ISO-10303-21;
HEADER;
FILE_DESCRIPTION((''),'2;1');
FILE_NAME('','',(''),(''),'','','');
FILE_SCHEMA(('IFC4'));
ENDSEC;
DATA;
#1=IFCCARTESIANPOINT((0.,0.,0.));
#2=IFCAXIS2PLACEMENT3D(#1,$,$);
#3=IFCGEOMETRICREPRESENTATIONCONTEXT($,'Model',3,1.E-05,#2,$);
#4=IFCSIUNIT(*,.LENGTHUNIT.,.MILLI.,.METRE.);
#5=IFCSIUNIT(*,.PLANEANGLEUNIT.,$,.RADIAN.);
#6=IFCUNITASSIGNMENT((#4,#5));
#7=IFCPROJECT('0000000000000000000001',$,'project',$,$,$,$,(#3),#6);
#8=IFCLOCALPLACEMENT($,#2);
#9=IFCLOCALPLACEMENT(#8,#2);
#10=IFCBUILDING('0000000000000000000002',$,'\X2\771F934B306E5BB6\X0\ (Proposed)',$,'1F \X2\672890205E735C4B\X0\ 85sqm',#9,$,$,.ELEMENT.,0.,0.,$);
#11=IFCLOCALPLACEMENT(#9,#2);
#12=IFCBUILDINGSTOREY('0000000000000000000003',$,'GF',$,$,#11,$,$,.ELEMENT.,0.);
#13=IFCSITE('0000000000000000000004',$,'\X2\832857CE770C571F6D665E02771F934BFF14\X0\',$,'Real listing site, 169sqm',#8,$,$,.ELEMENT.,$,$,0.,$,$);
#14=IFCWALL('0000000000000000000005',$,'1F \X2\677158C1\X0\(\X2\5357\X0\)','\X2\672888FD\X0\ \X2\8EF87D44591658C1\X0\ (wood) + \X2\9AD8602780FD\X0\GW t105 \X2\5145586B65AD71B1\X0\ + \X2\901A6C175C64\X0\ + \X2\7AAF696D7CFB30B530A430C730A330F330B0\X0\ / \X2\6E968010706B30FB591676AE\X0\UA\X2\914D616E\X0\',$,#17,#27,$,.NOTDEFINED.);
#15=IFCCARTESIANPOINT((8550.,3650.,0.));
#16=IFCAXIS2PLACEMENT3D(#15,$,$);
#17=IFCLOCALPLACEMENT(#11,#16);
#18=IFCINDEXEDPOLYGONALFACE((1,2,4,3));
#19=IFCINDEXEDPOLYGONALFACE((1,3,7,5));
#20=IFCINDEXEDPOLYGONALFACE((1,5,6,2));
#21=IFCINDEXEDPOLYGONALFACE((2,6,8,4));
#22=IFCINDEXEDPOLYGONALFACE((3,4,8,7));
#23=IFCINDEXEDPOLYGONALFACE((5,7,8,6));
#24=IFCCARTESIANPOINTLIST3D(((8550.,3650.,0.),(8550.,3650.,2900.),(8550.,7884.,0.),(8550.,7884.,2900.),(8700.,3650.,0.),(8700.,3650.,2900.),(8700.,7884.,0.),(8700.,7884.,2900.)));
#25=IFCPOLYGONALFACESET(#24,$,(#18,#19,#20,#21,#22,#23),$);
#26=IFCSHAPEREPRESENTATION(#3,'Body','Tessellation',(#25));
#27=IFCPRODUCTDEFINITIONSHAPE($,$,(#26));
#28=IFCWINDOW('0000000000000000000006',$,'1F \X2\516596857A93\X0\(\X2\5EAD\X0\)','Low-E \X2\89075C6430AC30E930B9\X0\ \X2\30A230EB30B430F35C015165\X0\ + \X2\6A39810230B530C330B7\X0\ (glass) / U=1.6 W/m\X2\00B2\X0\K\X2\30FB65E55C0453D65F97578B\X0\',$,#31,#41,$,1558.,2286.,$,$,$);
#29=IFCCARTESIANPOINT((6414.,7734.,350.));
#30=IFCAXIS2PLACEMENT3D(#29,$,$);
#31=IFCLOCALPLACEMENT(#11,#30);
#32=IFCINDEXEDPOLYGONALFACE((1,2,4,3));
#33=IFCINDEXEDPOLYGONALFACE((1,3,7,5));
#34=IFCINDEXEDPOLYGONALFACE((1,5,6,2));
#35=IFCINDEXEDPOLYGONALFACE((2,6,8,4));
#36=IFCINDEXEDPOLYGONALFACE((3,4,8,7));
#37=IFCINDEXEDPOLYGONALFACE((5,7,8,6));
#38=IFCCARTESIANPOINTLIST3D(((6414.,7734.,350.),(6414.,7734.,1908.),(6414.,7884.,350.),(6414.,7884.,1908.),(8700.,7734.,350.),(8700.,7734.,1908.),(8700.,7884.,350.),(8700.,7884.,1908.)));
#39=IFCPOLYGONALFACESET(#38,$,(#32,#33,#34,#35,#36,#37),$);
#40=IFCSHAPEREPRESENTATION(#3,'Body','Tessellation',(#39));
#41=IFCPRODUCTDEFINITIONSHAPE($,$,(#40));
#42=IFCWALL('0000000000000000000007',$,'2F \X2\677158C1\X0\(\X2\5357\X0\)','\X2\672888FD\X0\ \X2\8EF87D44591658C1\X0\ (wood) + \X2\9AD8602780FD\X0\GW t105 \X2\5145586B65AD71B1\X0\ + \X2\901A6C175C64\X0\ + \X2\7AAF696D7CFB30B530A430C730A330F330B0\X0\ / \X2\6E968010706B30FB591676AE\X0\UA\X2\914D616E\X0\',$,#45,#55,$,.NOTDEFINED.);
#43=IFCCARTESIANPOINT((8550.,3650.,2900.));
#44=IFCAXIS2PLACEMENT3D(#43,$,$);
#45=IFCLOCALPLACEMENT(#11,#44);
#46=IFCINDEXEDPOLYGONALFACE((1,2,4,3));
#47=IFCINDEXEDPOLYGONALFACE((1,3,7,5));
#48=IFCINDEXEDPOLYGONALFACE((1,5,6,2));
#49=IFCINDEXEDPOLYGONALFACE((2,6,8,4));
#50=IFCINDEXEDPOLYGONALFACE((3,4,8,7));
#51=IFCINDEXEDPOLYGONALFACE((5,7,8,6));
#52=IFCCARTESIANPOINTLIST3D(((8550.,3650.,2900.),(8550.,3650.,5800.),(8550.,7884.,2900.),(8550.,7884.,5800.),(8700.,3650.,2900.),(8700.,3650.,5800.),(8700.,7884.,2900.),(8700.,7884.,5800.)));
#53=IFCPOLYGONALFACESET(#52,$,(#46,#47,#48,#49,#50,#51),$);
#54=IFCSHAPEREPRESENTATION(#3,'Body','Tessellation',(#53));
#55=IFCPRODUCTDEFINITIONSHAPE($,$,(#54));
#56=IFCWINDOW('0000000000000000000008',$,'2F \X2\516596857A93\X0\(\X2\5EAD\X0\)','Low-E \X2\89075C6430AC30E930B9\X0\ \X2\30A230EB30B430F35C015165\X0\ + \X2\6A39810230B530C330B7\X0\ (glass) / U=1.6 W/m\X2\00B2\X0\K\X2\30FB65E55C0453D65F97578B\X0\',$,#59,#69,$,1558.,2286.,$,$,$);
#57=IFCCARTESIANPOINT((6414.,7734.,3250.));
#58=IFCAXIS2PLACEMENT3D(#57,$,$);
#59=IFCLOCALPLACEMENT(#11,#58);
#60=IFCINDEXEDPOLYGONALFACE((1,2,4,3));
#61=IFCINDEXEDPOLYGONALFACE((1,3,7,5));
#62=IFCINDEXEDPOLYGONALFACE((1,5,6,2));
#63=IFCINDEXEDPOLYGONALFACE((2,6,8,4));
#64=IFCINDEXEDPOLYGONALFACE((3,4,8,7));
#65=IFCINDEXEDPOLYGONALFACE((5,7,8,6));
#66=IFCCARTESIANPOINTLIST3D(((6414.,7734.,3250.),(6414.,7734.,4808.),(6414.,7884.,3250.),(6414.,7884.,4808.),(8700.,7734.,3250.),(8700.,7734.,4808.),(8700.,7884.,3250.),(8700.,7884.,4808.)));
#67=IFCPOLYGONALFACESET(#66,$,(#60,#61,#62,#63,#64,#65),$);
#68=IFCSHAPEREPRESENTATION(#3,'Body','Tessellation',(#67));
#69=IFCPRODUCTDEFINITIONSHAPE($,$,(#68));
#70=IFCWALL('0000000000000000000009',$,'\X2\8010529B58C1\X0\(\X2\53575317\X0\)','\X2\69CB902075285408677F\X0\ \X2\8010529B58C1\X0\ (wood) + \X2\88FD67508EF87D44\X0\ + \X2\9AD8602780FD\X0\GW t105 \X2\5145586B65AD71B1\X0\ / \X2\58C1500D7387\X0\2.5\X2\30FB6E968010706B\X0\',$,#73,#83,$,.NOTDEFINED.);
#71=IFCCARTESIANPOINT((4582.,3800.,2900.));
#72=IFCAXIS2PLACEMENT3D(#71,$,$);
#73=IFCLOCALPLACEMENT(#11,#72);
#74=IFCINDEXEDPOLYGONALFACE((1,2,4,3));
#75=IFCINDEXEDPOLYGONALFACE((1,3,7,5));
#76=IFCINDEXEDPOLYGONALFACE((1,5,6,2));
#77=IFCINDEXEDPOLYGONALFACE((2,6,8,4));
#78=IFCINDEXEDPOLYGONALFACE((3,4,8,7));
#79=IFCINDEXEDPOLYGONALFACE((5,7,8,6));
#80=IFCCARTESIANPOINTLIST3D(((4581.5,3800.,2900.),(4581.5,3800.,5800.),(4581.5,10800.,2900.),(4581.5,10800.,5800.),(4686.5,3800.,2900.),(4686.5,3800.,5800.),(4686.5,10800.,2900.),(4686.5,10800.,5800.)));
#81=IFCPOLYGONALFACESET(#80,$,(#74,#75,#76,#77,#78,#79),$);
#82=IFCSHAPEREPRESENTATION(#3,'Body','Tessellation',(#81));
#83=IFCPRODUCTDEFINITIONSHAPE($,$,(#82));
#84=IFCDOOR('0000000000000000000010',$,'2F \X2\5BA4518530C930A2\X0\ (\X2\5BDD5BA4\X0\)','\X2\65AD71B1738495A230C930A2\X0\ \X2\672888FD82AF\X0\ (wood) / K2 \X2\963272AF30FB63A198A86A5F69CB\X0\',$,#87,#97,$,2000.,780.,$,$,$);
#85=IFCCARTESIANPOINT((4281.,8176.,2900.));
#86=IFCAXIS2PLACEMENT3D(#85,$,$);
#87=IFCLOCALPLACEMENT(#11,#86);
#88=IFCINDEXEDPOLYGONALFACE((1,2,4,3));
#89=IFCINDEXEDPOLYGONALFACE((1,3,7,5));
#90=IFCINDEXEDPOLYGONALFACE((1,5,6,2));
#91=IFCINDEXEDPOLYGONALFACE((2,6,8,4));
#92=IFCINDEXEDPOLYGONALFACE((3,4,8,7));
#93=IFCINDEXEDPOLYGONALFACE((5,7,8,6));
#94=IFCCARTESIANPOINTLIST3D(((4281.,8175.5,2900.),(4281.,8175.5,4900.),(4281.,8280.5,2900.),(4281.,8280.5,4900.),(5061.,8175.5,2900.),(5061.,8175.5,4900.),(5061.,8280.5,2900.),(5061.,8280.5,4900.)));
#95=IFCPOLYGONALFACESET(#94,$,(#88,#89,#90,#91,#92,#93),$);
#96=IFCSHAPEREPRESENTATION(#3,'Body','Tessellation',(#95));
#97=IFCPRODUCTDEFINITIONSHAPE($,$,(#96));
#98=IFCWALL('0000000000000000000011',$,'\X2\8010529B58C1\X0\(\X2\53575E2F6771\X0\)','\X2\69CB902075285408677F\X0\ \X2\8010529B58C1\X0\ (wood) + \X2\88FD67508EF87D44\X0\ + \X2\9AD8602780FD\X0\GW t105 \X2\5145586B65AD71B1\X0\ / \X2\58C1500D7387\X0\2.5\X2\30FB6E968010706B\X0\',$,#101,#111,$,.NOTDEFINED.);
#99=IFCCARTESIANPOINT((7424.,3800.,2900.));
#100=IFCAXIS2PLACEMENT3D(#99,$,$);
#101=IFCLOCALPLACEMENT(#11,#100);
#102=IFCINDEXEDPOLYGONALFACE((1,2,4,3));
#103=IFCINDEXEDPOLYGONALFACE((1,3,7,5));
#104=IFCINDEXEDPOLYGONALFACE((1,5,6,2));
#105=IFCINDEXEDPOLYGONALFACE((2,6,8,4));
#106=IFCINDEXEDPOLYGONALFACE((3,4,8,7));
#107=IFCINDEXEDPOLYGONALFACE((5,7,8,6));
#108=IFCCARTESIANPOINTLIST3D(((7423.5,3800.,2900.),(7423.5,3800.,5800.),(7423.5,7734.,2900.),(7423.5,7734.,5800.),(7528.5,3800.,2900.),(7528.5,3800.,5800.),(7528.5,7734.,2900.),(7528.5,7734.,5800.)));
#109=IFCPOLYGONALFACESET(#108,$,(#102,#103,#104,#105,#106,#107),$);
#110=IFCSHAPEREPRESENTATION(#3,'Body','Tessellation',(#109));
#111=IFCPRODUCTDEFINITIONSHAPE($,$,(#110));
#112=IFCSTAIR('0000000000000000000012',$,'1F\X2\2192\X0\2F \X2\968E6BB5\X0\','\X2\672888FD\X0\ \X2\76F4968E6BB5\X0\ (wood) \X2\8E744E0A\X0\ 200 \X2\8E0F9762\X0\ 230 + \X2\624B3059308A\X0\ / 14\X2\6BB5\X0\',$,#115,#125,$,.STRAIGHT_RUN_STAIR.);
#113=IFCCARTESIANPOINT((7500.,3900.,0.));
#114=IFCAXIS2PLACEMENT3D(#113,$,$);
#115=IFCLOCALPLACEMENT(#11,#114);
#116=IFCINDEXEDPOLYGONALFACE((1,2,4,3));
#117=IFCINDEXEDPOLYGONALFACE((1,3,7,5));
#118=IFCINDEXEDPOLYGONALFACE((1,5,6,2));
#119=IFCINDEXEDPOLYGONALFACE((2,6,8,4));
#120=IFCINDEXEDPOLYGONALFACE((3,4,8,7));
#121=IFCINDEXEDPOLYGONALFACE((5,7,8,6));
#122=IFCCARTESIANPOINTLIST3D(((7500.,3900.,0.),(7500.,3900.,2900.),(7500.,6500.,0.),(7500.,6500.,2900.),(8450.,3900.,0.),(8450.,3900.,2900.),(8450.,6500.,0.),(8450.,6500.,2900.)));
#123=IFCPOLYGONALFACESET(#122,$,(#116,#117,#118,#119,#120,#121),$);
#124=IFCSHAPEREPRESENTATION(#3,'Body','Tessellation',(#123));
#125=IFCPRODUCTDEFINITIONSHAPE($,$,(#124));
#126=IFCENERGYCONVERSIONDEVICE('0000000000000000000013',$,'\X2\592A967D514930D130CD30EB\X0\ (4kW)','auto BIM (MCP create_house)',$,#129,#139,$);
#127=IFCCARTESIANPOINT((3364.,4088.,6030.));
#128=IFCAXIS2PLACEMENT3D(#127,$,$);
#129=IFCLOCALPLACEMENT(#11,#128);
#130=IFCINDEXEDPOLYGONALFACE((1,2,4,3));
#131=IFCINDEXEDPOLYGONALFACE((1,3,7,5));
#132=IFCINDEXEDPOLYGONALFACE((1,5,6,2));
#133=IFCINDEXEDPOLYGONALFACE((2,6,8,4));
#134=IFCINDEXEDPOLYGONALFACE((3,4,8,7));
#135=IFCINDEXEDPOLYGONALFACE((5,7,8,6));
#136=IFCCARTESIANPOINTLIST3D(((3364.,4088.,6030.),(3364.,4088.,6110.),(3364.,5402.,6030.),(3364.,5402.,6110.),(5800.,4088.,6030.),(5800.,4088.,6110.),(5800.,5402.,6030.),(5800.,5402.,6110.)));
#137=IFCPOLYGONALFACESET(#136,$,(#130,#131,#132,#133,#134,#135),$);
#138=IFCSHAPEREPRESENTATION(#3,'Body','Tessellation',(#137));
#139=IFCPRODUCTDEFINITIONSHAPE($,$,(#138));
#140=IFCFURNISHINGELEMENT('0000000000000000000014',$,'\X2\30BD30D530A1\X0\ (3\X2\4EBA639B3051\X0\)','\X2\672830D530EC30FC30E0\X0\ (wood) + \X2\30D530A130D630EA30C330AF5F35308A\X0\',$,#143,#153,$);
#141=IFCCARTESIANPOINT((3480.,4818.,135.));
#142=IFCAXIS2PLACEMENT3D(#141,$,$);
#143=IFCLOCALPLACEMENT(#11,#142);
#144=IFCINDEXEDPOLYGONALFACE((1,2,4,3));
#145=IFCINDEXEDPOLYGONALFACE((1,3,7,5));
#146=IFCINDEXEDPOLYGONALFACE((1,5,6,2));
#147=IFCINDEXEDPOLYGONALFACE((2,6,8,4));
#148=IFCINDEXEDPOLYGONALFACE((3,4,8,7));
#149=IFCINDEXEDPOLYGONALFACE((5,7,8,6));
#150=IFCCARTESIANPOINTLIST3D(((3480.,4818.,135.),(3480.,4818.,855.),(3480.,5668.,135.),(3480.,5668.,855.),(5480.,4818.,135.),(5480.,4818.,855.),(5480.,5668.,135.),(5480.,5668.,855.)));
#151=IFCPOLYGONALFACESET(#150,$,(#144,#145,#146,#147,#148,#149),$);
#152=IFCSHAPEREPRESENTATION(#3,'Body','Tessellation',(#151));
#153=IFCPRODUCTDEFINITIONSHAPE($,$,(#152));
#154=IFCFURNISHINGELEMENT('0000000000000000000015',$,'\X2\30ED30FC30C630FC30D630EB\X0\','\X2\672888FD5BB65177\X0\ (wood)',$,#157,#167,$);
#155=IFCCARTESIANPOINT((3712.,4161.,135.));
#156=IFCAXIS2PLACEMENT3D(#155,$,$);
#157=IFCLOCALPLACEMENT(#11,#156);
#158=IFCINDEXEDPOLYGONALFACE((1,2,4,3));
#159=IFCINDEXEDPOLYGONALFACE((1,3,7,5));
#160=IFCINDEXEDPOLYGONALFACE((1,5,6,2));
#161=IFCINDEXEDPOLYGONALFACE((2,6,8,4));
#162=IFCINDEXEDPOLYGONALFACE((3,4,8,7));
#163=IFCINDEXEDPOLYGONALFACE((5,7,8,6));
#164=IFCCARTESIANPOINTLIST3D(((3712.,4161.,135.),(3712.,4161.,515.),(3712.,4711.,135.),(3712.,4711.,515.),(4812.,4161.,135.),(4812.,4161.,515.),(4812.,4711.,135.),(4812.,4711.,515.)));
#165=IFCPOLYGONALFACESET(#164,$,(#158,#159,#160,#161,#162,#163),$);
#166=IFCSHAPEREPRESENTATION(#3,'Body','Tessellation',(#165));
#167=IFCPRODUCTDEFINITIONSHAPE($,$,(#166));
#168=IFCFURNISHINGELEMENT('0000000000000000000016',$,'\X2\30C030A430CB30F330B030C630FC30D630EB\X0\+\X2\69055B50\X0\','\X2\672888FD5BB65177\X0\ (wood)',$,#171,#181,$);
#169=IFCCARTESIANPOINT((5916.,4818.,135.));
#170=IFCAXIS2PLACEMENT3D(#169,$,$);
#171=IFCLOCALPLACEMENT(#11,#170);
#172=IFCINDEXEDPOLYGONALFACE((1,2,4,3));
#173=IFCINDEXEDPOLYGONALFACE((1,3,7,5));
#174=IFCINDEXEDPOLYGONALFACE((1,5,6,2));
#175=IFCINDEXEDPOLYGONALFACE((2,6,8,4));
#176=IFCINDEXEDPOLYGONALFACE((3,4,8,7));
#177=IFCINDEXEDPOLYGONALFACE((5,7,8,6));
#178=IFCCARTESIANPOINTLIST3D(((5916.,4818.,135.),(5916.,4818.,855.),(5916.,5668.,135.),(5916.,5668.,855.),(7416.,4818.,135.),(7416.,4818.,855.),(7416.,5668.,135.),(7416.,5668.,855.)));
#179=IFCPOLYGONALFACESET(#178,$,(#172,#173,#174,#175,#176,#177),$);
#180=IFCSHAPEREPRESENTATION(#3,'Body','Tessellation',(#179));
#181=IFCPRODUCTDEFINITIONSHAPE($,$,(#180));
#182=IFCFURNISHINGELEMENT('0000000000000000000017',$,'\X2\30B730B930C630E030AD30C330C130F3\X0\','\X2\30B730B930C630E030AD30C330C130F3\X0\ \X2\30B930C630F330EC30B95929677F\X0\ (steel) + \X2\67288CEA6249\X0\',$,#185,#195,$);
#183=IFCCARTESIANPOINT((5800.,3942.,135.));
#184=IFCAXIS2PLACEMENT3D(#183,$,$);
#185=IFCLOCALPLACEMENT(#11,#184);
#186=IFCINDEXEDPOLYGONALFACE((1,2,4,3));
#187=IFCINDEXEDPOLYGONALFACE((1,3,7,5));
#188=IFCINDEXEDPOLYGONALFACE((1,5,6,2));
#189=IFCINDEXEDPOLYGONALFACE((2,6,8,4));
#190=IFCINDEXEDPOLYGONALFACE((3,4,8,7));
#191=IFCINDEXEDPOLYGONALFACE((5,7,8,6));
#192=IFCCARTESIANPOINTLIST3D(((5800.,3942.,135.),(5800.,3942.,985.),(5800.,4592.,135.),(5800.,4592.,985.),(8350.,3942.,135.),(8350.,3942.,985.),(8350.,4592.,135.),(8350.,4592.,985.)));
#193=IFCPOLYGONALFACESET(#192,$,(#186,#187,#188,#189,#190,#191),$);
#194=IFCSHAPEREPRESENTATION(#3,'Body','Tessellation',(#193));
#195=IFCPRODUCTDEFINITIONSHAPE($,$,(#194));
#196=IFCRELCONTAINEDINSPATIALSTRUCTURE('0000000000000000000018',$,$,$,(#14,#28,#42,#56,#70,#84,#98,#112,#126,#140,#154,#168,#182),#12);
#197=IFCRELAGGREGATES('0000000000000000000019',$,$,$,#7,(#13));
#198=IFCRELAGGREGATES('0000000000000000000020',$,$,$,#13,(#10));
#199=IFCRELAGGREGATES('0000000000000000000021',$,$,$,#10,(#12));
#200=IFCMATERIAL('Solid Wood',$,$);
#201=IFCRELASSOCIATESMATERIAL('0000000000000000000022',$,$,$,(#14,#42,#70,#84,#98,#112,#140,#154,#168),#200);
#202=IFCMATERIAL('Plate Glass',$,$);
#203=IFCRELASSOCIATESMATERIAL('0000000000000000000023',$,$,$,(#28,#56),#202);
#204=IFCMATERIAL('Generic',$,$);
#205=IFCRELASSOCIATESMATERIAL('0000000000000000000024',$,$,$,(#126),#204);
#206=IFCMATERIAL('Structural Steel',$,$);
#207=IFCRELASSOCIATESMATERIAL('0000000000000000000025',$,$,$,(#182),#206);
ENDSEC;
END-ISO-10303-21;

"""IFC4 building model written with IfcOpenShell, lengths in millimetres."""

from ifc_helpers import new_model, si_unit, frame, frame_2d, origin, place, context, project, spatial, rectangle, extrude, material, element, fill, save


model = new_model("IFC4")

# Units and contexts
model_context = context("Model", 3, precision=1e-05, world=origin())
ifc_project = project(units=[si_unit("LENGTHUNIT", "METRE", prefix="MILLI"), si_unit("PLANEANGLEUNIT", "RADIAN")], contexts=[model_context])

# Site, building, storey
site_placement = place(None, origin())
site = spatial("IfcSite", under=ifc_project, at=site_placement, Name="茨城県土浦市真鍋４", ObjectType="Real listing site, 169sqm", CompositionType="ELEMENT", RefElevation=0.0)
building_placement = place(site_placement, origin())
building = spatial("IfcBuilding", under=site, at=building_placement, Name="真鍋の家 (Proposed)", ObjectType="1F 木造平屋 85sqm", CompositionType="ELEMENT", ElevationOfRefHeight=0.0, ElevationOfTerrain=0.0)
storey_placement = place(building_placement, origin())
storey = spatial("IfcBuildingStorey", under=building, at=storey_placement, Name="GF", CompositionType="ELEMENT", Elevation=0.0)

# Wall, opening, window
ifc_material_1 = material(Name="Solid Wood")
wall_1_placement = place(storey_placement, frame((8550.0, 3650.0, 0.0)))
wall_1 = element("IfcWall", 1, at=wall_1_placement, inside=storey, material=ifc_material_1, Name="1F 東壁(南)", Description="木製 軸組外壁 (wood) + 高性能GW t105 充填断熱 + 通気層 + 窯業系サイディング / 準耐火・外皮UA配慮", PredefinedType="NOTDEFINED", context=model_context, shape_type="SweptSolid", body=[
    extrude(rectangle(XDim=150.0, YDim=4234.0, at=frame_2d((75.0, 2117.0))), frame((8550.0, 3650.0, 0.0)), (0.0, 0.0, 1.0), 2900.0),
])
opening_1_placement = place(storey_placement, frame((6414.0, 7734.0, 350.0)))
opening_1 = element("IfcOpeningElement", 2, at=opening_1_placement, cuts=wall_1, PredefinedType="NOTDEFINED", context=model_context, shape_type="SweptSolid", body=[
    extrude(rectangle(XDim=2286.0, YDim=150.0, at=frame_2d((1143.0, 75.0))), frame((6414.0, 7734.0, 350.0)), (0.0, 0.0, 1.0), 1558.0),
])
ifc_material_2 = material(Name="Plate Glass")
window_1_placement = place(storey_placement, frame((6414.0, 7734.0, 350.0)))
window_1 = element("IfcWindow", 3, at=window_1_placement, inside=storey, material=ifc_material_2, Name="1F 入隅窓(庭)", Description="Low-E 複層ガラス アルゴン封入 + 樹脂サッシ (glass) / U=1.6 W/m²K・日射取得型", OverallHeight=1558.0, OverallWidth=2286.0, context=model_context, shape_type="SweptSolid", body=[
    extrude(rectangle(XDim=2286.0, YDim=150.0, at=frame_2d((1143.0, 75.0))), frame((6414.0, 7734.0, 350.0)), (0.0, 0.0, 1.0), 1558.0),
])
fill(opening_1, window_1)

# Wall, opening, window
wall_2_placement = place(storey_placement, frame((8550.0, 3650.0, 2900.0)))
wall_2 = element("IfcWall", 4, at=wall_2_placement, inside=storey, material=ifc_material_1, Name="2F 東壁(南)", Description="木製 軸組外壁 (wood) + 高性能GW t105 充填断熱 + 通気層 + 窯業系サイディング / 準耐火・外皮UA配慮", PredefinedType="NOTDEFINED", context=model_context, shape_type="SweptSolid", body=[
    extrude(rectangle(XDim=150.0, YDim=4234.0, at=frame_2d((75.0, 2117.0))), frame((8550.0, 3650.0, 2900.0)), (0.0, 0.0, 1.0), 2900.0),
])
opening_2_placement = place(storey_placement, frame((6414.0, 7734.0, 3250.0)))
opening_2 = element("IfcOpeningElement", 5, at=opening_2_placement, cuts=wall_2, PredefinedType="NOTDEFINED", context=model_context, shape_type="SweptSolid", body=[
    extrude(rectangle(XDim=2286.0, YDim=150.0, at=frame_2d((1143.0, 75.0))), frame((6414.0, 7734.0, 3250.0)), (0.0, 0.0, 1.0), 1558.0),
])
window_2_placement = place(storey_placement, frame((6414.0, 7734.0, 3250.0)))
window_2 = element("IfcWindow", 6, at=window_2_placement, inside=storey, material=ifc_material_2, Name="2F 入隅窓(庭)", Description="Low-E 複層ガラス アルゴン封入 + 樹脂サッシ (glass) / U=1.6 W/m²K・日射取得型", OverallHeight=1558.0, OverallWidth=2286.0, context=model_context, shape_type="SweptSolid", body=[
    extrude(rectangle(XDim=2286.0, YDim=150.0, at=frame_2d((1143.0, 75.0))), frame((6414.0, 7734.0, 3250.0)), (0.0, 0.0, 1.0), 1558.0),
])
fill(opening_2, window_2)

# Wall, opening, door
wall_3_placement = place(storey_placement, frame((4582.0, 3800.0, 2900.0)))
wall_3 = element("IfcWall", 7, at=wall_3_placement, inside=storey, material=ifc_material_1, Name="耐力壁(南北)", Description="構造用合板 耐力壁 (wood) + 製材軸組 + 高性能GW t105 充填断熱 / 壁倍率2.5・準耐火", PredefinedType="NOTDEFINED", context=model_context, shape_type="SweptSolid", body=[
    extrude(rectangle(XDim=105.0, YDim=7000.0, at=frame_2d((52.0, 3500.0))), frame((4582.0, 3800.0, 2900.0)), (0.0, 0.0, 1.0), 2900.0),
])
opening_3_placement = place(storey_placement, frame((4281.0, 8176.0, 2900.0)))
opening_3 = element("IfcOpeningElement", 8, at=opening_3_placement, cuts=wall_3, PredefinedType="NOTDEFINED", context=model_context, shape_type="SweptSolid", body=[
    extrude(rectangle(XDim=780.0, YDim=105.0, at=frame_2d((390.0, 52.0))), frame((4281.0, 8176.0, 2900.0)), (0.0, 0.0, 1.0), 2000.0),
])
door_1_placement = place(storey_placement, frame((4281.0, 8176.0, 2900.0)))
door_1 = element("IfcDoor", 9, at=door_1_placement, inside=storey, material=ifc_material_1, Name="2F 室内ドア (寝室)", Description="断熱玄関ドア 木製芯 (wood) / K2 防犯・採風機構", OverallHeight=2000.0, OverallWidth=780.0, context=model_context, shape_type="SweptSolid", body=[
    extrude(rectangle(XDim=780.0, YDim=105.0, at=frame_2d((390.0, 52.0))), frame((4281.0, 8176.0, 2900.0)), (0.0, 0.0, 1.0), 2000.0),
])
fill(opening_3, door_1)

# Wall
wall_4_placement = place(storey_placement, frame((7424.0, 3800.0, 2900.0)))
element("IfcWall", 10, at=wall_4_placement, inside=storey, material=ifc_material_1, Name="耐力壁(南帯東)", Description="構造用合板 耐力壁 (wood) + 製材軸組 + 高性能GW t105 充填断熱 / 壁倍率2.5・準耐火", PredefinedType="NOTDEFINED", context=model_context, shape_type="SweptSolid", body=[
    extrude(rectangle(XDim=105.0, YDim=3934.0, at=frame_2d((52.0, 1967.0))), frame((7424.0, 3800.0, 2900.0)), (0.0, 0.0, 1.0), 2900.0),
])

# Stair
stair_placement = place(storey_placement, frame((7500.0, 3900.0, 0.0)))
element("IfcStair", 11, at=stair_placement, inside=storey, material=ifc_material_1, Name="1F→2F 階段", Description="木製 直階段 (wood) 蹴上 200 踏面 230 + 手すり / 14段", PredefinedType="STRAIGHT_RUN_STAIR", context=model_context, shape_type="SweptSolid", body=[
    extrude(rectangle(XDim=950.0, YDim=2600.0, at=frame_2d((475.0, 1300.0))), frame((7500.0, 3900.0, 0.0)), (0.0, 0.0, 1.0), 2900.0),
])

# Energy conversion device
ifc_material_3 = material(Name="Generic")
energy_conversion_device_placement = place(storey_placement, frame((3364.0, 4088.0, 6030.0)))
element("IfcEnergyConversionDevice", 12, at=energy_conversion_device_placement, inside=storey, material=ifc_material_3, Name="太陽光パネル (4kW)", Description="auto BIM (MCP create_house)", context=model_context, shape_type="SweptSolid", body=[
    extrude(rectangle(XDim=2436.0, YDim=1314.0, at=frame_2d((1218.0, 657.0))), frame((3364.0, 4088.0, 6030.0)), (0.0, 0.0, 1.0), 80.0),
])

# Furnishing elements
furnishing_1_placement = place(storey_placement, frame((3480.0, 4818.0, 135.0)))
element("IfcFurnishingElement", 13, at=furnishing_1_placement, inside=storey, material=ifc_material_1, Name="ソファ (3人掛け)", Description="木フレーム (wood) + ファブリック張り", context=model_context, shape_type="SweptSolid", body=[
    extrude(rectangle(XDim=2000.0, YDim=850.0, at=frame_2d((1000.0, 425.0))), frame((3480.0, 4818.0, 135.0)), (0.0, 0.0, 1.0), 720.0),
])
furnishing_2_placement = place(storey_placement, frame((3712.0, 4161.0, 135.0)))
element("IfcFurnishingElement", 14, at=furnishing_2_placement, inside=storey, material=ifc_material_1, Name="ローテーブル", Description="木製家具 (wood)", context=model_context, shape_type="SweptSolid", body=[
    extrude(rectangle(XDim=1100.0, YDim=550.0, at=frame_2d((550.0, 275.0))), frame((3712.0, 4161.0, 135.0)), (0.0, 0.0, 1.0), 380.0),
])
furnishing_3_placement = place(storey_placement, frame((5916.0, 4818.0, 135.0)))
element("IfcFurnishingElement", 15, at=furnishing_3_placement, inside=storey, material=ifc_material_1, Name="ダイニングテーブル+椅子", Description="木製家具 (wood)", context=model_context, shape_type="SweptSolid", body=[
    extrude(rectangle(XDim=1500.0, YDim=850.0, at=frame_2d((750.0, 425.0))), frame((5916.0, 4818.0, 135.0)), (0.0, 0.0, 1.0), 720.0),
])
ifc_material_4 = material(Name="Structural Steel")
furnishing_4_placement = place(storey_placement, frame((5800.0, 3942.0, 135.0)))
element("IfcFurnishingElement", 16, at=furnishing_4_placement, inside=storey, material=ifc_material_4, Name="システムキッチン", Description="システムキッチン ステンレス天板 (steel) + 木質扉", context=model_context, shape_type="SweptSolid", body=[
    extrude(rectangle(XDim=2550.0, YDim=650.0, at=frame_2d((1275.0, 325.0))), frame((5800.0, 3942.0, 135.0)), (0.0, 0.0, 1.0), 850.0),
])

save(model, "model.ifc")
